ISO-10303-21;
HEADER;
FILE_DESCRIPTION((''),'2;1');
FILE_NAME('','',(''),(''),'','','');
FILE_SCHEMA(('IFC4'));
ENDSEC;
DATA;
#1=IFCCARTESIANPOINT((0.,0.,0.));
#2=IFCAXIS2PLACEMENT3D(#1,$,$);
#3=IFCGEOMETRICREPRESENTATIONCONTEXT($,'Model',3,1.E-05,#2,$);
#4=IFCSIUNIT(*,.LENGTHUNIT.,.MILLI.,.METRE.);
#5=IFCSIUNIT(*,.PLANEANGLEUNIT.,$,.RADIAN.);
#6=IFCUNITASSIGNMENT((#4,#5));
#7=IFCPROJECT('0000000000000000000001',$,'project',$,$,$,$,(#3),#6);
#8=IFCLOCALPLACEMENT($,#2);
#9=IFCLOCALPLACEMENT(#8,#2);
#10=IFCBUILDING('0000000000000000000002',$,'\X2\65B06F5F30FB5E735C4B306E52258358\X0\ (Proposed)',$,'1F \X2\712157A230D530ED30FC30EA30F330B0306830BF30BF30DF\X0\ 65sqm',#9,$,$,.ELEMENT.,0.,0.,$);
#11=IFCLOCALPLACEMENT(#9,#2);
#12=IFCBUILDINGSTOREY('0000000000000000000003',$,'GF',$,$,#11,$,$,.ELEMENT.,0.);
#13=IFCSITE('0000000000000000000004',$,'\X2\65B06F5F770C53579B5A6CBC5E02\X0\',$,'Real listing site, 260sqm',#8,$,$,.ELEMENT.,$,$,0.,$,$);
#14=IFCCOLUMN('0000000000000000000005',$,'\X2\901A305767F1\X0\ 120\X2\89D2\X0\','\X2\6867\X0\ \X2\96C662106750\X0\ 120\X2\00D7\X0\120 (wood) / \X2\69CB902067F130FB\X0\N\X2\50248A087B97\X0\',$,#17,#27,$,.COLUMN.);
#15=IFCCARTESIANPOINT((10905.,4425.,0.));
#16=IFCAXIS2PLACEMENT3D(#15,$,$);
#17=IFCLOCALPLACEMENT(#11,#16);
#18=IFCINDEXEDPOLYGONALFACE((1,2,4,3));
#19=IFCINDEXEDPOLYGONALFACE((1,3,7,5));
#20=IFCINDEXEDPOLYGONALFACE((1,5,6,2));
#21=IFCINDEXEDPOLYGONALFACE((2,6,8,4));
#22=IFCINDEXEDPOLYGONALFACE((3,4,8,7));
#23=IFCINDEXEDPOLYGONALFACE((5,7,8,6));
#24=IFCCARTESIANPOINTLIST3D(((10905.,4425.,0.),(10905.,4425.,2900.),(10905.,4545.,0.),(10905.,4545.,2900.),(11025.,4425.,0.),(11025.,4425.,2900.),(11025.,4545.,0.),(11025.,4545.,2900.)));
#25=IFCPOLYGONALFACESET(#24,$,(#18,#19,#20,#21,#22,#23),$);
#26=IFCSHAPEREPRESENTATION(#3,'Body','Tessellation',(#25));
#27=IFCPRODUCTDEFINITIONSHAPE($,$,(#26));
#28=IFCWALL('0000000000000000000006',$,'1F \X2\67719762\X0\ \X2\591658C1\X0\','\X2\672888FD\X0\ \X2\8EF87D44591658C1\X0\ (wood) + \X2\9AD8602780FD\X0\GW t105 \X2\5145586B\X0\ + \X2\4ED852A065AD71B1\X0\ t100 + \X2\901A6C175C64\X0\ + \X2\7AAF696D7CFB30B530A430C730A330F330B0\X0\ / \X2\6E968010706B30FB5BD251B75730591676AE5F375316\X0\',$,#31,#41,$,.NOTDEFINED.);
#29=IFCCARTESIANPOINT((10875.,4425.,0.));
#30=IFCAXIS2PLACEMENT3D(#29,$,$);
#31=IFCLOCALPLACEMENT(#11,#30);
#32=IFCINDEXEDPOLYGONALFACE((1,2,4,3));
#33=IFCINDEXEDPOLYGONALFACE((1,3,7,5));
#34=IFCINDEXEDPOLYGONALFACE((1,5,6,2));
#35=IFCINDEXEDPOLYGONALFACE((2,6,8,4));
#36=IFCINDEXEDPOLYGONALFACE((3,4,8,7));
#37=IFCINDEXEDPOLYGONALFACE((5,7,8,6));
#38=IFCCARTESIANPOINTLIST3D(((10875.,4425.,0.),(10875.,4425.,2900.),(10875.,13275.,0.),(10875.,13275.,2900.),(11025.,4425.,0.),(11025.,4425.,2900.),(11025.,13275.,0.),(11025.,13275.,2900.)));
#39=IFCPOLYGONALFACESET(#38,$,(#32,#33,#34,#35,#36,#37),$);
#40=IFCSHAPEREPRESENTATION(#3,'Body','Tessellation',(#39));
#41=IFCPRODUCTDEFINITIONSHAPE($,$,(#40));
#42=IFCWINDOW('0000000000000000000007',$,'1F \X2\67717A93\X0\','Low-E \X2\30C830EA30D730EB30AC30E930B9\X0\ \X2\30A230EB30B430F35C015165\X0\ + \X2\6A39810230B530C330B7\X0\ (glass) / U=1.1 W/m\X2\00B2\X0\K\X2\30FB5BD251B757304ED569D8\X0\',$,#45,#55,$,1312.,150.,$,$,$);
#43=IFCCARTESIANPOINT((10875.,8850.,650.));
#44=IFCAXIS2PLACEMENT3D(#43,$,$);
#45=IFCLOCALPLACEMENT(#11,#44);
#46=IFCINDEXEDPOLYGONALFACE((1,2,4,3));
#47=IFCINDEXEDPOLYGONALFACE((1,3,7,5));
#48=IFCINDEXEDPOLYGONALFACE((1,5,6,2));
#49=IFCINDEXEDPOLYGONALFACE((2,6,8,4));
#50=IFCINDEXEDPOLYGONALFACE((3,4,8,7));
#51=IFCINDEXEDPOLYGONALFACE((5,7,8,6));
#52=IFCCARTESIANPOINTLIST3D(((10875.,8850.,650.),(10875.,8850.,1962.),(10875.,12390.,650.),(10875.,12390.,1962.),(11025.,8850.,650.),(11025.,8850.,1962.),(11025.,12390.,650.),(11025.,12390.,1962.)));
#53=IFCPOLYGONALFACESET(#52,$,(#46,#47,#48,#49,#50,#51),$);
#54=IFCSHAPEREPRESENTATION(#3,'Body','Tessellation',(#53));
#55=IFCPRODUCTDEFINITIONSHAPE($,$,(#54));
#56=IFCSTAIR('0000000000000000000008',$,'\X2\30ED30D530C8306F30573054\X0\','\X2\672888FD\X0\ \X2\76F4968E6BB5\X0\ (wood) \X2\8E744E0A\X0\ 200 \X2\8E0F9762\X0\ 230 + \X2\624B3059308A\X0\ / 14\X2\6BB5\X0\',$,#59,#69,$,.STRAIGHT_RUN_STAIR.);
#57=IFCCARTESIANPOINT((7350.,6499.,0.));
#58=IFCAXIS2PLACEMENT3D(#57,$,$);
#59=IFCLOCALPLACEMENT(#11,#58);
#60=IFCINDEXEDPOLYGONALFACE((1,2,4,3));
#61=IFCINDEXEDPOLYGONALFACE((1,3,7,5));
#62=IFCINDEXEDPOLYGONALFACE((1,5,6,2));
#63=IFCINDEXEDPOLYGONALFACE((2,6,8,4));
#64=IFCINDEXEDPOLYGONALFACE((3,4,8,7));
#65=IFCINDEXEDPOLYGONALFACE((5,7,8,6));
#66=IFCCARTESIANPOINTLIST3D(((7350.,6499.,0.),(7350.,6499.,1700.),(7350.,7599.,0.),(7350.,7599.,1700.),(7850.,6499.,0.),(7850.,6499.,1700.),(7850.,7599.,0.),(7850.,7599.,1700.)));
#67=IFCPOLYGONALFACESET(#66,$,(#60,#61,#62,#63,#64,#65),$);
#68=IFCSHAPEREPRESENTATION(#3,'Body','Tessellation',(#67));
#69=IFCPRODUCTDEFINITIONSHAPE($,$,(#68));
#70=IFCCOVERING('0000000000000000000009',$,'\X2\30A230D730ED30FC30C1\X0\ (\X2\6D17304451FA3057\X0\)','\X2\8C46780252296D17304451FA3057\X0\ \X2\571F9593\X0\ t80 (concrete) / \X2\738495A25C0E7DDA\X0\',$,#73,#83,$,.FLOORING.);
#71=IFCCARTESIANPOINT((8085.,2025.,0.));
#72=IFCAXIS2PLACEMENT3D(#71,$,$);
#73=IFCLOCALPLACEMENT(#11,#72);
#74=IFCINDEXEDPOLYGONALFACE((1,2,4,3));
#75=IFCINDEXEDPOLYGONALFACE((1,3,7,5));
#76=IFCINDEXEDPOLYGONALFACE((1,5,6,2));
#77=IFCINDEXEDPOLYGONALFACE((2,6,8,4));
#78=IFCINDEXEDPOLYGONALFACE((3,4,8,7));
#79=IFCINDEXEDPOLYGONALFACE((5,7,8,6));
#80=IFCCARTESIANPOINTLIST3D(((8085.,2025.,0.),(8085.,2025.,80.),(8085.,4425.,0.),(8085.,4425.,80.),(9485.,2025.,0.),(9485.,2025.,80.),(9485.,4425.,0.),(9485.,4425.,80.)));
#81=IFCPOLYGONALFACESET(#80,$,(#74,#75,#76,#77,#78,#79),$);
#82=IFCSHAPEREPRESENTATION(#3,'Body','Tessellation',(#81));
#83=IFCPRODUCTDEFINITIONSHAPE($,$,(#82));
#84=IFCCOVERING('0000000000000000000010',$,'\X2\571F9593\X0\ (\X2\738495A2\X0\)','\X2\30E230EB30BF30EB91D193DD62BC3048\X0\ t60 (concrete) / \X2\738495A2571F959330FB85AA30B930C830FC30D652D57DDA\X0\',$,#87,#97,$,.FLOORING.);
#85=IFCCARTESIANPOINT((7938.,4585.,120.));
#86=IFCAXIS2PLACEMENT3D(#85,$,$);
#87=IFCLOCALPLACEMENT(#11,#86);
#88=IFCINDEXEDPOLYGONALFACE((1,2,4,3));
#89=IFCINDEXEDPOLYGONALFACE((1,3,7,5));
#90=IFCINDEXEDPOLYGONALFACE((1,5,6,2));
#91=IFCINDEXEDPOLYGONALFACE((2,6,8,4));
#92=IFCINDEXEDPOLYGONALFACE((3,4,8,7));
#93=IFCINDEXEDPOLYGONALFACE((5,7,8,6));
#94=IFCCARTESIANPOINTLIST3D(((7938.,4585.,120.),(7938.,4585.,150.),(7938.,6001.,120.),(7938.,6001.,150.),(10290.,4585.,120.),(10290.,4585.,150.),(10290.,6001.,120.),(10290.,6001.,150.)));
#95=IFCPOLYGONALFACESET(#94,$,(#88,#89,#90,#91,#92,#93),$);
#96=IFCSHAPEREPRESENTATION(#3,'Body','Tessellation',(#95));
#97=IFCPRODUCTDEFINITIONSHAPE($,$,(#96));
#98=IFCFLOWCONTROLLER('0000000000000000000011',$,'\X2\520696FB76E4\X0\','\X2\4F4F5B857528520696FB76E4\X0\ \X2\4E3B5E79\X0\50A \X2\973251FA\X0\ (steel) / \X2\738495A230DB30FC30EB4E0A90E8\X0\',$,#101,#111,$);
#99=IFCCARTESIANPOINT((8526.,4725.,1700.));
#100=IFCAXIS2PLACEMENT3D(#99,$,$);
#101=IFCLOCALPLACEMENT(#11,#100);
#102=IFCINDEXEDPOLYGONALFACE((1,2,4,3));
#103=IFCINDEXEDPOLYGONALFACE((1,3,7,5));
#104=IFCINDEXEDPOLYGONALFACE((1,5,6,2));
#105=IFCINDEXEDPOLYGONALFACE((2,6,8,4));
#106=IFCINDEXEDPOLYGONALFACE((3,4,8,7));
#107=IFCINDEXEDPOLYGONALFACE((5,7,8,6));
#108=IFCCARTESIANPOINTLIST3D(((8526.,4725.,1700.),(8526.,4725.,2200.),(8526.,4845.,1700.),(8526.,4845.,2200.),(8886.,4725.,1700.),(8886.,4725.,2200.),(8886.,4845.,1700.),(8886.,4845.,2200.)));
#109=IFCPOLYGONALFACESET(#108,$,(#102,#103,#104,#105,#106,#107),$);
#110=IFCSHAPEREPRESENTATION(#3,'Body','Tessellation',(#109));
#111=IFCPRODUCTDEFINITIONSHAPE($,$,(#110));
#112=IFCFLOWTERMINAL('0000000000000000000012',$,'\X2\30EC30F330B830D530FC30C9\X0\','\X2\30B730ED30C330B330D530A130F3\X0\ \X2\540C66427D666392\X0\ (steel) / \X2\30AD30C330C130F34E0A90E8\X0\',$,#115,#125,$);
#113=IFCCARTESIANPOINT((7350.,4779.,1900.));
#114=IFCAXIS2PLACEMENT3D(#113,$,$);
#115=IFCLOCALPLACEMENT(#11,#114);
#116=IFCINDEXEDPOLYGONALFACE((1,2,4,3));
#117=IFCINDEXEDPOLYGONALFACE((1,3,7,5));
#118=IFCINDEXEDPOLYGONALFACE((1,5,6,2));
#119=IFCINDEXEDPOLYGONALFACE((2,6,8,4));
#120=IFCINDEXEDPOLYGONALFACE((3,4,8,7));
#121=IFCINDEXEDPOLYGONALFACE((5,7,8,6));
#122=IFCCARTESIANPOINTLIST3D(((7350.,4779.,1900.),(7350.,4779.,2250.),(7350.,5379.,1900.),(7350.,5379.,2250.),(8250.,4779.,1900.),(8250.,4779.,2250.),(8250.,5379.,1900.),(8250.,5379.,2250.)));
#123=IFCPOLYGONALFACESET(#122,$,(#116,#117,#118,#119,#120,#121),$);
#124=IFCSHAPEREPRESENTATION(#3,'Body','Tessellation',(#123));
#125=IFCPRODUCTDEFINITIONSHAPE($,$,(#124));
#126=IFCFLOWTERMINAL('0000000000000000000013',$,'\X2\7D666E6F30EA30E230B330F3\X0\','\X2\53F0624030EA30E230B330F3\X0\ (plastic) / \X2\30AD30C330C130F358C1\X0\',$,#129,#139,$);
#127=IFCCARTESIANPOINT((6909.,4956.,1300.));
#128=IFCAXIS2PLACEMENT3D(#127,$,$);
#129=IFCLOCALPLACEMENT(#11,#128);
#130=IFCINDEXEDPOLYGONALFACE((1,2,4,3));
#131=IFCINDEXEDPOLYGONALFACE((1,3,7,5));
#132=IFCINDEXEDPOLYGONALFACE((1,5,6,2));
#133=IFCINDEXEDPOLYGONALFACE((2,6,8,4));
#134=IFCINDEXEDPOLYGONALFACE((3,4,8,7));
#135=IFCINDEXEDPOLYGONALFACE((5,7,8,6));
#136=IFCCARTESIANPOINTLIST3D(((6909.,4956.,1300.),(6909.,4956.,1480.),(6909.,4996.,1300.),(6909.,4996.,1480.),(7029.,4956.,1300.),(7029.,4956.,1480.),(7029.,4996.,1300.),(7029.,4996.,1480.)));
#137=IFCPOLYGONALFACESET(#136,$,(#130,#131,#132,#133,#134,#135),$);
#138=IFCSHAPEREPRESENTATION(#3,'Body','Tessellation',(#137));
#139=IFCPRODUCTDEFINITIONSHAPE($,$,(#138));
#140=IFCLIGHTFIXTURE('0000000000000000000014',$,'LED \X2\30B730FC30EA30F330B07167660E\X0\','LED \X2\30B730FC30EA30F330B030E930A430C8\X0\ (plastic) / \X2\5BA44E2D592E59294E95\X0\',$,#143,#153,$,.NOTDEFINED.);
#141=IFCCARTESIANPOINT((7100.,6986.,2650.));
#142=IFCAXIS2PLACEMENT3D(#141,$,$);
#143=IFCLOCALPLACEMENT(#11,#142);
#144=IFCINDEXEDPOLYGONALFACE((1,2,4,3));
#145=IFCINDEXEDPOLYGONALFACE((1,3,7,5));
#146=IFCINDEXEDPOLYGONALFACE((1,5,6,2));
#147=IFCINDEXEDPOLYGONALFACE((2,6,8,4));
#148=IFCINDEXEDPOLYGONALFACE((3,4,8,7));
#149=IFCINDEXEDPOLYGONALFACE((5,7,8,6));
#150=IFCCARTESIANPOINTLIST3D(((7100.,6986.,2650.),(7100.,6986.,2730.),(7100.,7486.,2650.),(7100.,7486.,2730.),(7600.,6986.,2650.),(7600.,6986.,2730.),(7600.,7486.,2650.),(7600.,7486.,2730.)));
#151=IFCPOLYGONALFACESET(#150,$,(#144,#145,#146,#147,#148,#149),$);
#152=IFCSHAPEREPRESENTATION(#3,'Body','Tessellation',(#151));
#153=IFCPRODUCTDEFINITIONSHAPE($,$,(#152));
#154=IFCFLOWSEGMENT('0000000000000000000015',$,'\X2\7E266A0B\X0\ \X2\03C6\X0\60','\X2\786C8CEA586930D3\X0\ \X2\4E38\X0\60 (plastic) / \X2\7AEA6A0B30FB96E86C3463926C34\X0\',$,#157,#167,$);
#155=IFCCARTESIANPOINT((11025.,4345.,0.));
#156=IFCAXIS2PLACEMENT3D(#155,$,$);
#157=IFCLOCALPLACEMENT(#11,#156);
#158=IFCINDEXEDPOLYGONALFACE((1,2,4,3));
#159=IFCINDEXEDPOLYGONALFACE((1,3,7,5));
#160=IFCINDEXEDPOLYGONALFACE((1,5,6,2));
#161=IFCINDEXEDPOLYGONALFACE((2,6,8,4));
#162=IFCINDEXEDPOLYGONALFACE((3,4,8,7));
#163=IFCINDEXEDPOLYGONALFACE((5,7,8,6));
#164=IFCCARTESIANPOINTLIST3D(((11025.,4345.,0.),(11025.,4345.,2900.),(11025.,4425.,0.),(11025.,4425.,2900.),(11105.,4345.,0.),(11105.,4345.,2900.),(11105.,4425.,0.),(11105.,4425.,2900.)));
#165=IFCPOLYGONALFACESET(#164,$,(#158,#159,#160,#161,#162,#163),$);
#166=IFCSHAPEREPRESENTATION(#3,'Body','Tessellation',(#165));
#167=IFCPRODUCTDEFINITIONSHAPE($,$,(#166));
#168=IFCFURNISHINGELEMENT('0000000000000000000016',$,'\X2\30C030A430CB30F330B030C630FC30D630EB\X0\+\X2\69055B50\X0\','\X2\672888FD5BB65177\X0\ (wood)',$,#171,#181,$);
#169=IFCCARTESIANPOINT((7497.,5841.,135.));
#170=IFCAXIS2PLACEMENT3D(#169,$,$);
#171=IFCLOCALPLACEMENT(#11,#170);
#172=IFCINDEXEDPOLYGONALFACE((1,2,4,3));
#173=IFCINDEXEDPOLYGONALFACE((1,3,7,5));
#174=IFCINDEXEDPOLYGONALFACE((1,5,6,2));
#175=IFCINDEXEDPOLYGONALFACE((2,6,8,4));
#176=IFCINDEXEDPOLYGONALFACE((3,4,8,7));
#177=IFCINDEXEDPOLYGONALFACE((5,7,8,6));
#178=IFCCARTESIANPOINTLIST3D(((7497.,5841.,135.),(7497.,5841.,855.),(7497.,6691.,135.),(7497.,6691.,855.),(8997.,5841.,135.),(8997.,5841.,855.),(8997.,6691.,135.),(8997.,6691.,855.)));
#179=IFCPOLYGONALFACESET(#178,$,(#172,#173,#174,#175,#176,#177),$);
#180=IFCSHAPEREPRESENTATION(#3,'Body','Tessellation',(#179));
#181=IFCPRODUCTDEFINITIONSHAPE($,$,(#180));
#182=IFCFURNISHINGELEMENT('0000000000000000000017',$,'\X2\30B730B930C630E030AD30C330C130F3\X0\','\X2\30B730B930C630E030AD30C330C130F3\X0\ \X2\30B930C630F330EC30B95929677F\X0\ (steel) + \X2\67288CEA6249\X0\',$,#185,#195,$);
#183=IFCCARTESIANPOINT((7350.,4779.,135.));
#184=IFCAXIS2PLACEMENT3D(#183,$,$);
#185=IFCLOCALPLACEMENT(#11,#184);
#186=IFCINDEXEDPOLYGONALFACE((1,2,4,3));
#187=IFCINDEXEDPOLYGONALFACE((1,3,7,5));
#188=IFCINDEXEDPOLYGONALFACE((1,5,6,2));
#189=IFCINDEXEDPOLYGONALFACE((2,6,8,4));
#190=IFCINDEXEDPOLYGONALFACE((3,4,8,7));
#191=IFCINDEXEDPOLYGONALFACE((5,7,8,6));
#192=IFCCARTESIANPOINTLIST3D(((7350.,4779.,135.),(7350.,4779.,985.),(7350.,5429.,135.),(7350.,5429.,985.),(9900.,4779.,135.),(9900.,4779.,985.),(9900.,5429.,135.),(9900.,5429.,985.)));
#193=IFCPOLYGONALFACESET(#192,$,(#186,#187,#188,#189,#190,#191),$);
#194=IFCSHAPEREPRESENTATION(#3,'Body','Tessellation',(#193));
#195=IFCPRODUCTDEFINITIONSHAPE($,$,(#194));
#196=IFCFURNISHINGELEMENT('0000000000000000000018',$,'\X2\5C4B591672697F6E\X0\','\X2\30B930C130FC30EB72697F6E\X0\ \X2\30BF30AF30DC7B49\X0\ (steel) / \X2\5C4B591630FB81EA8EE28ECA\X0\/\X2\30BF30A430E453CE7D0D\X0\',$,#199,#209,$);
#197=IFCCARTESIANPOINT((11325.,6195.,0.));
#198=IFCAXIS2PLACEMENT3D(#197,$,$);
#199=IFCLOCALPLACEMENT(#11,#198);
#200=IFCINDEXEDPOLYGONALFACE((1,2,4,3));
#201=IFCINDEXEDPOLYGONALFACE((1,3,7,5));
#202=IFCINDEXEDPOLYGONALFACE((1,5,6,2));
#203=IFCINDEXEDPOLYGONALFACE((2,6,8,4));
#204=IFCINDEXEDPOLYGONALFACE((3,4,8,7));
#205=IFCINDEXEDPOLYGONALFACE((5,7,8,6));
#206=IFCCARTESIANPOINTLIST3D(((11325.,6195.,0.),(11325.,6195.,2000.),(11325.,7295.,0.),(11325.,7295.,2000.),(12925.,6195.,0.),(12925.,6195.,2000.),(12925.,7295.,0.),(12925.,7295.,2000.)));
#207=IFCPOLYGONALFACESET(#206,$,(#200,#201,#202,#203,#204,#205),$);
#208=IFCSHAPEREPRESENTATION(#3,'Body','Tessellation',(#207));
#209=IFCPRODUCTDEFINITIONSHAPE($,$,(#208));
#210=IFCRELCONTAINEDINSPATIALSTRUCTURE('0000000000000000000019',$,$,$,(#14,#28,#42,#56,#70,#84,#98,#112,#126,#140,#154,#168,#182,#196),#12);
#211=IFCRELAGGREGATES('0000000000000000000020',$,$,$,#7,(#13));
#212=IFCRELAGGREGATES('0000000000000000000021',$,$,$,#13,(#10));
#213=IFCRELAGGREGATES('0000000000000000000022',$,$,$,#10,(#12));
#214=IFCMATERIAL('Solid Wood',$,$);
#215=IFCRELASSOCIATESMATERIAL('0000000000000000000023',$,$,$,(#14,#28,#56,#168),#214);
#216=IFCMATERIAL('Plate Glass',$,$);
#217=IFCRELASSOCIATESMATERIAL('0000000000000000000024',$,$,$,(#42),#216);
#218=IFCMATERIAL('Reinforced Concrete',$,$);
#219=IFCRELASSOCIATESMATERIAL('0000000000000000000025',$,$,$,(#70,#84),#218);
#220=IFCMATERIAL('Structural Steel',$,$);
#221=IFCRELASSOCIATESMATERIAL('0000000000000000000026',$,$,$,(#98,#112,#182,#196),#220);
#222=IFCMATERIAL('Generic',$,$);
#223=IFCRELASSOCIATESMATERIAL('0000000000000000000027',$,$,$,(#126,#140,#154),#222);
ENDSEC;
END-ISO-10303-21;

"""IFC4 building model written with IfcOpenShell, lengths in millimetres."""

from ifc_helpers import new_model, si_unit, frame, frame_2d, origin, place, context, project, spatial, rectangle, extrude, material, element, fill, save


model = new_model("IFC4")

# Units and contexts
model_context = context("Model", 3, precision=1e-05, world=origin())
ifc_project = project(units=[si_unit("LENGTHUNIT", "METRE", prefix="MILLI"), si_unit("PLANEANGLEUNIT", "RADIAN")], contexts=[model_context])

# Site, building, storey
site_placement = place(None, origin())
site = spatial("IfcSite", under=ifc_project, at=site_placement, Name="新潟県南魚沼市", ObjectType="Real listing site, 260sqm", CompositionType="ELEMENT", RefElevation=0.0)
building_placement = place(site_placement, origin())
building = spatial("IfcBuilding", under=site, at=building_placement, Name="新潟・平屋の別荘 (Proposed)", ObjectType="1F 無垢フローリングとタタミ 65sqm", CompositionType="ELEMENT", ElevationOfRefHeight=0.0, ElevationOfTerrain=0.0)
storey_placement = place(building_placement, origin())
storey = spatial("IfcBuildingStorey", under=building, at=storey_placement, Name="GF", CompositionType="ELEMENT", Elevation=0.0)

# Column
ifc_material_1 = material(Name="Solid Wood")
column_1_placement = place(storey_placement, frame((10905.0, 4425.0, 0.0)))
element("IfcColumn", 1, at=column_1_placement, inside=storey, material=ifc_material_1, Name="通し柱 120角", Description="桧 集成材 120×120 (wood) / 構造柱・N値計算", PredefinedType="COLUMN", context=model_context, shape_type="SweptSolid", body=[
    extrude(rectangle(XDim=120.0, YDim=120.0, at=frame_2d((60.0, 60.0))), frame((10905.0, 4425.0, 0.0)), (0.0, 0.0, 1.0), 2900.0),
])

# Wall, opening, window
wall_1_placement = place(storey_placement, frame((10875.0, 4425.0, 0.0)))
wall_1 = element("IfcWall", 2, at=wall_1_placement, inside=storey, material=ifc_material_1, Name="1F 東面 外壁", Description="木製 軸組外壁 (wood) + 高性能GW t105 充填 + 付加断熱 t100 + 通気層 + 窯業系サイディング / 準耐火・寒冷地外皮強化", PredefinedType="NOTDEFINED", context=model_context, shape_type="SweptSolid", body=[
    extrude(rectangle(XDim=150.0, YDim=8850.0, at=frame_2d((75.0, 4425.0))), frame((10875.0, 4425.0, 0.0)), (0.0, 0.0, 1.0), 2900.0),
])
opening_placement = place(storey_placement, frame((10875.0, 8850.0, 650.0)))
opening = element("IfcOpeningElement", 3, at=opening_placement, cuts=wall_1, PredefinedType="NOTDEFINED", context=model_context, shape_type="SweptSolid", body=[
    extrude(rectangle(XDim=150.0, YDim=3540.0, at=frame_2d((75.0, 1770.0))), frame((10875.0, 8850.0, 650.0)), (0.0, 0.0, 1.0), 1312.0),
])
ifc_material_2 = material(Name="Plate Glass")
window_placement = place(storey_placement, frame((10875.0, 8850.0, 650.0)))
window = element("IfcWindow", 4, at=window_placement, inside=storey, material=ifc_material_2, Name="1F 東窓", Description="Low-E トリプルガラス アルゴン封入 + 樹脂サッシ (glass) / U=1.1 W/m²K・寒冷地仕様", OverallHeight=1312.0, OverallWidth=150.0, context=model_context, shape_type="SweptSolid", body=[
    extrude(rectangle(XDim=150.0, YDim=3540.0, at=frame_2d((75.0, 1770.0))), frame((10875.0, 8850.0, 650.0)), (0.0, 0.0, 1.0), 1312.0),
])
fill(opening, window)

# Stair
stair_placement = place(storey_placement, frame((7350.0, 6499.0, 0.0)))
element("IfcStair", 5, at=stair_placement, inside=storey, material=ifc_material_1, Name="ロフトはしご", Description="木製 直階段 (wood) 蹴上 200 踏面 230 + 手すり / 14段", PredefinedType="STRAIGHT_RUN_STAIR", context=model_context, shape_type="SweptSolid", body=[
    extrude(rectangle(XDim=500.0, YDim=1100.0, at=frame_2d((250.0, 550.0))), frame((7350.0, 6499.0, 0.0)), (0.0, 0.0, 1.0), 1700.0),
])

# Coverings
ifc_material_3 = material(Name="Reinforced Concrete")
covering_1_placement = place(storey_placement, frame((8085.0, 2025.0, 0.0)))
element("IfcCovering", 6, at=covering_1_placement, inside=storey, material=ifc_material_3, Name="アプローチ (洗い出し)", Description="豆砂利洗い出し 土間 t80 (concrete) / 玄関導線", PredefinedType="FLOORING", context=model_context, shape_type="SweptSolid", body=[
    extrude(rectangle(XDim=1400.0, YDim=2400.0, at=frame_2d((700.0, 1200.0))), frame((8085.0, 2025.0, 0.0)), (0.0, 0.0, 1.0), 80.0),
])
covering_2_placement = place(storey_placement, frame((7938.0, 4585.0, 120.0)))
element("IfcCovering", 7, at=covering_2_placement, inside=storey, material=ifc_material_3, Name="土間 (玄関)", Description="モルタル金鏝押え t60 (concrete) / 玄関土間・薪ストーブ動線", PredefinedType="FLOORING", context=model_context, shape_type="SweptSolid", body=[
    extrude(rectangle(XDim=2352.0, YDim=1416.0, at=frame_2d((1176.0, 708.0))), frame((7938.0, 4585.0, 120.0)), (0.0, 0.0, 1.0), 30.0),
])

# Flow controller
ifc_material_4 = material(Name="Structural Steel")
flow_controller_placement = place(storey_placement, frame((8526.0, 4725.0, 1700.0)))
element("IfcFlowController", 8, at=flow_controller_placement, inside=storey, material=ifc_material_4, Name="分電盤", Description="住宅用分電盤 主幹50A 露出 (steel) / 玄関ホール上部", context=model_context, shape_type="SweptSolid", body=[
    extrude(rectangle(XDim=360.0, YDim=120.0, at=frame_2d((180.0, 60.0))), frame((8526.0, 4725.0, 1700.0)), (0.0, 0.0, 1.0), 500.0),
])

# Flow terminals
flow_terminal_1_placement = place(storey_placement, frame((7350.0, 4779.0, 1900.0)))
element("IfcFlowTerminal", 9, at=flow_terminal_1_placement, inside=storey, material=ifc_material_4, Name="レンジフード", Description="シロッコファン 同時給排 (steel) / キッチン上部", context=model_context, shape_type="SweptSolid", body=[
    extrude(rectangle(XDim=900.0, YDim=600.0, at=frame_2d((450.0, 300.0))), frame((7350.0, 4779.0, 1900.0)), (0.0, 0.0, 1.0), 350.0),
])
ifc_material_5 = material(Name="Generic")
flow_terminal_2_placement = place(storey_placement, frame((6909.0, 4956.0, 1300.0)))
element("IfcFlowTerminal", 10, at=flow_terminal_2_placement, inside=storey, material=ifc_material_5, Name="給湯リモコン", Description="台所リモコン (plastic) / キッチン壁", context=model_context, shape_type="SweptSolid", body=[
    extrude(rectangle(XDim=120.0, YDim=40.0, at=frame_2d((60.0, 20.0))), frame((6909.0, 4956.0, 1300.0)), (0.0, 0.0, 1.0), 180.0),
])

# Light fixture
light_fixture_placement = place(storey_placement, frame((7100.0, 6986.0, 2650.0)))
element("IfcLightFixture", 11, at=light_fixture_placement, inside=storey, material=ifc_material_5, Name="LED シーリング照明", Description="LED シーリングライト (plastic) / 室中央天井", PredefinedType="NOTDEFINED", context=model_context, shape_type="SweptSolid", body=[
    extrude(rectangle(XDim=500.0, YDim=500.0, at=frame_2d((250.0, 250.0))), frame((7100.0, 6986.0, 2650.0)), (0.0, 0.0, 1.0), 80.0),
])

# Flow segment
flow_segment_placement = place(storey_placement, frame((11025.0, 4345.0, 0.0)))
element("IfcFlowSegment", 12, at=flow_segment_placement, inside=storey, material=ifc_material_5, Name="縦樋 φ60", Description="硬質塩ビ 丸60 (plastic) / 竪樋・雨水排水", context=model_context, shape_type="SweptSolid", body=[
    extrude(rectangle(XDim=80.0, YDim=80.0, at=frame_2d((40.0, 40.0))), frame((11025.0, 4345.0, 0.0)), (0.0, 0.0, 1.0), 2900.0),
])

# Furnishing elements
furnishing_1_placement = place(storey_placement, frame((7497.0, 5841.0, 135.0)))
element("IfcFurnishingElement", 13, at=furnishing_1_placement, inside=storey, material=ifc_material_1, Name="ダイニングテーブル+椅子", Description="木製家具 (wood)", context=model_context, shape_type="SweptSolid", body=[
    extrude(rectangle(XDim=1500.0, YDim=850.0, at=frame_2d((750.0, 425.0))), frame((7497.0, 5841.0, 135.0)), (0.0, 0.0, 1.0), 720.0),
])
furnishing_2_placement = place(storey_placement, frame((7350.0, 4779.0, 135.0)))
element("IfcFurnishingElement", 14, at=furnishing_2_placement, inside=storey, material=ifc_material_4, Name="システムキッチン", Description="システムキッチン ステンレス天板 (steel) + 木質扉", context=model_context, shape_type="SweptSolid", body=[
    extrude(rectangle(XDim=2550.0, YDim=650.0, at=frame_2d((1275.0, 325.0))), frame((7350.0, 4779.0, 135.0)), (0.0, 0.0, 1.0), 850.0),
])
furnishing_3_placement = place(storey_placement, frame((11325.0, 6195.0, 0.0)))
element("IfcFurnishingElement", 15, at=furnishing_3_placement, inside=storey, material=ifc_material_4, Name="屋外物置", Description="スチール物置 タクボ等 (steel) / 屋外・自転車/タイヤ収納", context=model_context, shape_type="SweptSolid", body=[
    extrude(rectangle(XDim=1600.0, YDim=1100.0, at=frame_2d((800.0, 550.0))), frame((11325.0, 6195.0, 0.0)), (0.0, 0.0, 1.0), 2000.0),
])

save(model, "model.ifc")
